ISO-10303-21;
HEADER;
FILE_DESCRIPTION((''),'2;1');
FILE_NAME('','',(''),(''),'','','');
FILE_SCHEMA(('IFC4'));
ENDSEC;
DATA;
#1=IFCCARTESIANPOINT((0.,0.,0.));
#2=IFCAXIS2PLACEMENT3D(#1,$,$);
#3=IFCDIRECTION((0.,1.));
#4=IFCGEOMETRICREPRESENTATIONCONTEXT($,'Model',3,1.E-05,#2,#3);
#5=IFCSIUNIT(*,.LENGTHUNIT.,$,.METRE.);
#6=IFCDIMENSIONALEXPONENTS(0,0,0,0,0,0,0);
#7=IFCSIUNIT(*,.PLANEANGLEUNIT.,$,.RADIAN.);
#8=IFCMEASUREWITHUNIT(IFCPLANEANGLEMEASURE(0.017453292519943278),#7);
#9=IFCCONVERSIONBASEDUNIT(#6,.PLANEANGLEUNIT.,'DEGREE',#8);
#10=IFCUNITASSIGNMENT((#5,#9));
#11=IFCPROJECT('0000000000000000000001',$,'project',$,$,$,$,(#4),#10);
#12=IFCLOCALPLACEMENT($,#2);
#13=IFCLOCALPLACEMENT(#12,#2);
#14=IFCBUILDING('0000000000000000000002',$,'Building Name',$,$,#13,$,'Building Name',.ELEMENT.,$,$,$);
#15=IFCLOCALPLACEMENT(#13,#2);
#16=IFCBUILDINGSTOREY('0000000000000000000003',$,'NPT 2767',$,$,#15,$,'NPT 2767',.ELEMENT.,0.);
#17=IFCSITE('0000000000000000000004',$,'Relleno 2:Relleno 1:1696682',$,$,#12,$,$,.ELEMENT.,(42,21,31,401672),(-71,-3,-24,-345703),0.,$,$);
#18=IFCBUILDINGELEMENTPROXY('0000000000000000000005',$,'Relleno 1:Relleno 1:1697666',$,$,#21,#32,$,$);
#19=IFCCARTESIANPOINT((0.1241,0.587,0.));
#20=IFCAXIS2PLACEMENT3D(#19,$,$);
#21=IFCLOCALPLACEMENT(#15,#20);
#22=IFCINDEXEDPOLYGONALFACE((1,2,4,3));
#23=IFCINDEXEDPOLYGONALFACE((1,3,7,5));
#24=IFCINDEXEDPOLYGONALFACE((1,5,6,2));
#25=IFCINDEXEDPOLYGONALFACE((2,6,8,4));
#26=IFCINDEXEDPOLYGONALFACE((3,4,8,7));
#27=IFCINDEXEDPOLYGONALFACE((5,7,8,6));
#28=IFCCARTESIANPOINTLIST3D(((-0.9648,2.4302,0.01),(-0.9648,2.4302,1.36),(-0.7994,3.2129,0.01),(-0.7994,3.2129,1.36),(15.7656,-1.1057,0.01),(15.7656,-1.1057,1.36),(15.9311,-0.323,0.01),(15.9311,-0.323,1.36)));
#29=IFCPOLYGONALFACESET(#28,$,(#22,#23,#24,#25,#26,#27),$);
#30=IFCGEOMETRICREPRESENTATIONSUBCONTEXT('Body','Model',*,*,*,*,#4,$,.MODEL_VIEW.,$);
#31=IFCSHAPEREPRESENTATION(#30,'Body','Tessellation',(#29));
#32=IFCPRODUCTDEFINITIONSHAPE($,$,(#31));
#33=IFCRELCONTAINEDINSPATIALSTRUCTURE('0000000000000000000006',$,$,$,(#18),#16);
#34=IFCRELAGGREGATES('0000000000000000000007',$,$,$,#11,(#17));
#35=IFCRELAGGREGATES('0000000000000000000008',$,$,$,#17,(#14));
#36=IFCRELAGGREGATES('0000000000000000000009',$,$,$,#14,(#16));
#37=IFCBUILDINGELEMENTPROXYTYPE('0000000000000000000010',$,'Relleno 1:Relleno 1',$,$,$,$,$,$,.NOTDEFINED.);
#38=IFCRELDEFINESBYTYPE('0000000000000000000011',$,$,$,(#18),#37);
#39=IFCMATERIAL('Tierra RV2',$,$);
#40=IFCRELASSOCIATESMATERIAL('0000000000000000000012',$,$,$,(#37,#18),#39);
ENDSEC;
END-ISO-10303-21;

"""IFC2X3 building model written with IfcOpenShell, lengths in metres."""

from ifc_helpers import new_model, entity, si_unit, converted_unit, direction, frame, frame_2d, origin, place, context, subcontext, project, spatial, rectangle, extrude, source, transform, mapped, material, type_object, type_shapes, element, save


model = new_model("IFC2X3")

# Units and contexts
model_context = context("Model", 3, precision=1e-05, world=origin(), true_north=direction((0.0, 1.0)))
body_context = subcontext(model_context, "Body", "Model", "MODEL_VIEW")
ifc_project = project(units=[si_unit("LENGTHUNIT", "METRE"), converted_unit("PLANEANGLEUNIT", "DEGREE", entity("IfcPlaneAngleMeasure", 0.017453292519943278), si_unit("PLANEANGLEUNIT", "RADIAN"), dimensions=[0, 0, 0, 0, 0, 0, 0])], contexts=[model_context])

# Site, building, storey
site_placement = place(None, origin())
site = spatial("IfcSite", under=ifc_project, at=site_placement, Name="Relleno 2:Relleno 1:1696682", CompositionType="ELEMENT", RefLatitude=(42, 21, 31, 401672), RefLongitude=(-71, -3, -24, -345703), RefElevation=0.0)
building_placement = place(site_placement, origin())
building = spatial("IfcBuilding", under=site, at=building_placement, Name="Building Name", LongName="Building Name", CompositionType="ELEMENT")
storey_placement = place(building_placement, origin())
storey = spatial("IfcBuildingStorey", under=building, at=storey_placement, Name="NPT 2767", LongName="NPT 2767", CompositionType="ELEMENT", Elevation=0.0)

# Building element proxy
ifc_material_1 = material(Name="Tierra RV2")
building_element_proxy_type_1 = type_object("IfcBuildingElementProxyType", Name="Relleno 1:Relleno 1", PredefinedType="NOTDEFINED", material=ifc_material_1)
shared_shape_1 = source(origin(), body_context, "Body", "SweptSolid", [
    extrude(rectangle(XDim=17.1, YDim=0.8, at=frame_2d((0.0, 0.0), x_axis=(1.0, 0.0))), frame((7.4831, 1.0536, 0.01), z_axis=(0.0, 0.0, 1.0), x_axis=(0.978388, -0.206778, 0.0)), (0.0, 0.0, 1.0), 1.35),
])
type_shapes(building_element_proxy_type_1, [shared_shape_1])
proxy_1_placement = place(storey_placement, frame((0.1241, 0.587, 0.0)))
element("IfcBuildingElementProxy", 1, at=proxy_1_placement, inside=storey, type_object=building_element_proxy_type_1, material=ifc_material_1, Name="Relleno 1:Relleno 1:1697666", context=body_context, shape_type="MappedRepresentation", body=[
    mapped(shared_shape_1, transform((0.0, 0.0, 0.0), scale=1.0)),
])

save(model, "model.ifc")
